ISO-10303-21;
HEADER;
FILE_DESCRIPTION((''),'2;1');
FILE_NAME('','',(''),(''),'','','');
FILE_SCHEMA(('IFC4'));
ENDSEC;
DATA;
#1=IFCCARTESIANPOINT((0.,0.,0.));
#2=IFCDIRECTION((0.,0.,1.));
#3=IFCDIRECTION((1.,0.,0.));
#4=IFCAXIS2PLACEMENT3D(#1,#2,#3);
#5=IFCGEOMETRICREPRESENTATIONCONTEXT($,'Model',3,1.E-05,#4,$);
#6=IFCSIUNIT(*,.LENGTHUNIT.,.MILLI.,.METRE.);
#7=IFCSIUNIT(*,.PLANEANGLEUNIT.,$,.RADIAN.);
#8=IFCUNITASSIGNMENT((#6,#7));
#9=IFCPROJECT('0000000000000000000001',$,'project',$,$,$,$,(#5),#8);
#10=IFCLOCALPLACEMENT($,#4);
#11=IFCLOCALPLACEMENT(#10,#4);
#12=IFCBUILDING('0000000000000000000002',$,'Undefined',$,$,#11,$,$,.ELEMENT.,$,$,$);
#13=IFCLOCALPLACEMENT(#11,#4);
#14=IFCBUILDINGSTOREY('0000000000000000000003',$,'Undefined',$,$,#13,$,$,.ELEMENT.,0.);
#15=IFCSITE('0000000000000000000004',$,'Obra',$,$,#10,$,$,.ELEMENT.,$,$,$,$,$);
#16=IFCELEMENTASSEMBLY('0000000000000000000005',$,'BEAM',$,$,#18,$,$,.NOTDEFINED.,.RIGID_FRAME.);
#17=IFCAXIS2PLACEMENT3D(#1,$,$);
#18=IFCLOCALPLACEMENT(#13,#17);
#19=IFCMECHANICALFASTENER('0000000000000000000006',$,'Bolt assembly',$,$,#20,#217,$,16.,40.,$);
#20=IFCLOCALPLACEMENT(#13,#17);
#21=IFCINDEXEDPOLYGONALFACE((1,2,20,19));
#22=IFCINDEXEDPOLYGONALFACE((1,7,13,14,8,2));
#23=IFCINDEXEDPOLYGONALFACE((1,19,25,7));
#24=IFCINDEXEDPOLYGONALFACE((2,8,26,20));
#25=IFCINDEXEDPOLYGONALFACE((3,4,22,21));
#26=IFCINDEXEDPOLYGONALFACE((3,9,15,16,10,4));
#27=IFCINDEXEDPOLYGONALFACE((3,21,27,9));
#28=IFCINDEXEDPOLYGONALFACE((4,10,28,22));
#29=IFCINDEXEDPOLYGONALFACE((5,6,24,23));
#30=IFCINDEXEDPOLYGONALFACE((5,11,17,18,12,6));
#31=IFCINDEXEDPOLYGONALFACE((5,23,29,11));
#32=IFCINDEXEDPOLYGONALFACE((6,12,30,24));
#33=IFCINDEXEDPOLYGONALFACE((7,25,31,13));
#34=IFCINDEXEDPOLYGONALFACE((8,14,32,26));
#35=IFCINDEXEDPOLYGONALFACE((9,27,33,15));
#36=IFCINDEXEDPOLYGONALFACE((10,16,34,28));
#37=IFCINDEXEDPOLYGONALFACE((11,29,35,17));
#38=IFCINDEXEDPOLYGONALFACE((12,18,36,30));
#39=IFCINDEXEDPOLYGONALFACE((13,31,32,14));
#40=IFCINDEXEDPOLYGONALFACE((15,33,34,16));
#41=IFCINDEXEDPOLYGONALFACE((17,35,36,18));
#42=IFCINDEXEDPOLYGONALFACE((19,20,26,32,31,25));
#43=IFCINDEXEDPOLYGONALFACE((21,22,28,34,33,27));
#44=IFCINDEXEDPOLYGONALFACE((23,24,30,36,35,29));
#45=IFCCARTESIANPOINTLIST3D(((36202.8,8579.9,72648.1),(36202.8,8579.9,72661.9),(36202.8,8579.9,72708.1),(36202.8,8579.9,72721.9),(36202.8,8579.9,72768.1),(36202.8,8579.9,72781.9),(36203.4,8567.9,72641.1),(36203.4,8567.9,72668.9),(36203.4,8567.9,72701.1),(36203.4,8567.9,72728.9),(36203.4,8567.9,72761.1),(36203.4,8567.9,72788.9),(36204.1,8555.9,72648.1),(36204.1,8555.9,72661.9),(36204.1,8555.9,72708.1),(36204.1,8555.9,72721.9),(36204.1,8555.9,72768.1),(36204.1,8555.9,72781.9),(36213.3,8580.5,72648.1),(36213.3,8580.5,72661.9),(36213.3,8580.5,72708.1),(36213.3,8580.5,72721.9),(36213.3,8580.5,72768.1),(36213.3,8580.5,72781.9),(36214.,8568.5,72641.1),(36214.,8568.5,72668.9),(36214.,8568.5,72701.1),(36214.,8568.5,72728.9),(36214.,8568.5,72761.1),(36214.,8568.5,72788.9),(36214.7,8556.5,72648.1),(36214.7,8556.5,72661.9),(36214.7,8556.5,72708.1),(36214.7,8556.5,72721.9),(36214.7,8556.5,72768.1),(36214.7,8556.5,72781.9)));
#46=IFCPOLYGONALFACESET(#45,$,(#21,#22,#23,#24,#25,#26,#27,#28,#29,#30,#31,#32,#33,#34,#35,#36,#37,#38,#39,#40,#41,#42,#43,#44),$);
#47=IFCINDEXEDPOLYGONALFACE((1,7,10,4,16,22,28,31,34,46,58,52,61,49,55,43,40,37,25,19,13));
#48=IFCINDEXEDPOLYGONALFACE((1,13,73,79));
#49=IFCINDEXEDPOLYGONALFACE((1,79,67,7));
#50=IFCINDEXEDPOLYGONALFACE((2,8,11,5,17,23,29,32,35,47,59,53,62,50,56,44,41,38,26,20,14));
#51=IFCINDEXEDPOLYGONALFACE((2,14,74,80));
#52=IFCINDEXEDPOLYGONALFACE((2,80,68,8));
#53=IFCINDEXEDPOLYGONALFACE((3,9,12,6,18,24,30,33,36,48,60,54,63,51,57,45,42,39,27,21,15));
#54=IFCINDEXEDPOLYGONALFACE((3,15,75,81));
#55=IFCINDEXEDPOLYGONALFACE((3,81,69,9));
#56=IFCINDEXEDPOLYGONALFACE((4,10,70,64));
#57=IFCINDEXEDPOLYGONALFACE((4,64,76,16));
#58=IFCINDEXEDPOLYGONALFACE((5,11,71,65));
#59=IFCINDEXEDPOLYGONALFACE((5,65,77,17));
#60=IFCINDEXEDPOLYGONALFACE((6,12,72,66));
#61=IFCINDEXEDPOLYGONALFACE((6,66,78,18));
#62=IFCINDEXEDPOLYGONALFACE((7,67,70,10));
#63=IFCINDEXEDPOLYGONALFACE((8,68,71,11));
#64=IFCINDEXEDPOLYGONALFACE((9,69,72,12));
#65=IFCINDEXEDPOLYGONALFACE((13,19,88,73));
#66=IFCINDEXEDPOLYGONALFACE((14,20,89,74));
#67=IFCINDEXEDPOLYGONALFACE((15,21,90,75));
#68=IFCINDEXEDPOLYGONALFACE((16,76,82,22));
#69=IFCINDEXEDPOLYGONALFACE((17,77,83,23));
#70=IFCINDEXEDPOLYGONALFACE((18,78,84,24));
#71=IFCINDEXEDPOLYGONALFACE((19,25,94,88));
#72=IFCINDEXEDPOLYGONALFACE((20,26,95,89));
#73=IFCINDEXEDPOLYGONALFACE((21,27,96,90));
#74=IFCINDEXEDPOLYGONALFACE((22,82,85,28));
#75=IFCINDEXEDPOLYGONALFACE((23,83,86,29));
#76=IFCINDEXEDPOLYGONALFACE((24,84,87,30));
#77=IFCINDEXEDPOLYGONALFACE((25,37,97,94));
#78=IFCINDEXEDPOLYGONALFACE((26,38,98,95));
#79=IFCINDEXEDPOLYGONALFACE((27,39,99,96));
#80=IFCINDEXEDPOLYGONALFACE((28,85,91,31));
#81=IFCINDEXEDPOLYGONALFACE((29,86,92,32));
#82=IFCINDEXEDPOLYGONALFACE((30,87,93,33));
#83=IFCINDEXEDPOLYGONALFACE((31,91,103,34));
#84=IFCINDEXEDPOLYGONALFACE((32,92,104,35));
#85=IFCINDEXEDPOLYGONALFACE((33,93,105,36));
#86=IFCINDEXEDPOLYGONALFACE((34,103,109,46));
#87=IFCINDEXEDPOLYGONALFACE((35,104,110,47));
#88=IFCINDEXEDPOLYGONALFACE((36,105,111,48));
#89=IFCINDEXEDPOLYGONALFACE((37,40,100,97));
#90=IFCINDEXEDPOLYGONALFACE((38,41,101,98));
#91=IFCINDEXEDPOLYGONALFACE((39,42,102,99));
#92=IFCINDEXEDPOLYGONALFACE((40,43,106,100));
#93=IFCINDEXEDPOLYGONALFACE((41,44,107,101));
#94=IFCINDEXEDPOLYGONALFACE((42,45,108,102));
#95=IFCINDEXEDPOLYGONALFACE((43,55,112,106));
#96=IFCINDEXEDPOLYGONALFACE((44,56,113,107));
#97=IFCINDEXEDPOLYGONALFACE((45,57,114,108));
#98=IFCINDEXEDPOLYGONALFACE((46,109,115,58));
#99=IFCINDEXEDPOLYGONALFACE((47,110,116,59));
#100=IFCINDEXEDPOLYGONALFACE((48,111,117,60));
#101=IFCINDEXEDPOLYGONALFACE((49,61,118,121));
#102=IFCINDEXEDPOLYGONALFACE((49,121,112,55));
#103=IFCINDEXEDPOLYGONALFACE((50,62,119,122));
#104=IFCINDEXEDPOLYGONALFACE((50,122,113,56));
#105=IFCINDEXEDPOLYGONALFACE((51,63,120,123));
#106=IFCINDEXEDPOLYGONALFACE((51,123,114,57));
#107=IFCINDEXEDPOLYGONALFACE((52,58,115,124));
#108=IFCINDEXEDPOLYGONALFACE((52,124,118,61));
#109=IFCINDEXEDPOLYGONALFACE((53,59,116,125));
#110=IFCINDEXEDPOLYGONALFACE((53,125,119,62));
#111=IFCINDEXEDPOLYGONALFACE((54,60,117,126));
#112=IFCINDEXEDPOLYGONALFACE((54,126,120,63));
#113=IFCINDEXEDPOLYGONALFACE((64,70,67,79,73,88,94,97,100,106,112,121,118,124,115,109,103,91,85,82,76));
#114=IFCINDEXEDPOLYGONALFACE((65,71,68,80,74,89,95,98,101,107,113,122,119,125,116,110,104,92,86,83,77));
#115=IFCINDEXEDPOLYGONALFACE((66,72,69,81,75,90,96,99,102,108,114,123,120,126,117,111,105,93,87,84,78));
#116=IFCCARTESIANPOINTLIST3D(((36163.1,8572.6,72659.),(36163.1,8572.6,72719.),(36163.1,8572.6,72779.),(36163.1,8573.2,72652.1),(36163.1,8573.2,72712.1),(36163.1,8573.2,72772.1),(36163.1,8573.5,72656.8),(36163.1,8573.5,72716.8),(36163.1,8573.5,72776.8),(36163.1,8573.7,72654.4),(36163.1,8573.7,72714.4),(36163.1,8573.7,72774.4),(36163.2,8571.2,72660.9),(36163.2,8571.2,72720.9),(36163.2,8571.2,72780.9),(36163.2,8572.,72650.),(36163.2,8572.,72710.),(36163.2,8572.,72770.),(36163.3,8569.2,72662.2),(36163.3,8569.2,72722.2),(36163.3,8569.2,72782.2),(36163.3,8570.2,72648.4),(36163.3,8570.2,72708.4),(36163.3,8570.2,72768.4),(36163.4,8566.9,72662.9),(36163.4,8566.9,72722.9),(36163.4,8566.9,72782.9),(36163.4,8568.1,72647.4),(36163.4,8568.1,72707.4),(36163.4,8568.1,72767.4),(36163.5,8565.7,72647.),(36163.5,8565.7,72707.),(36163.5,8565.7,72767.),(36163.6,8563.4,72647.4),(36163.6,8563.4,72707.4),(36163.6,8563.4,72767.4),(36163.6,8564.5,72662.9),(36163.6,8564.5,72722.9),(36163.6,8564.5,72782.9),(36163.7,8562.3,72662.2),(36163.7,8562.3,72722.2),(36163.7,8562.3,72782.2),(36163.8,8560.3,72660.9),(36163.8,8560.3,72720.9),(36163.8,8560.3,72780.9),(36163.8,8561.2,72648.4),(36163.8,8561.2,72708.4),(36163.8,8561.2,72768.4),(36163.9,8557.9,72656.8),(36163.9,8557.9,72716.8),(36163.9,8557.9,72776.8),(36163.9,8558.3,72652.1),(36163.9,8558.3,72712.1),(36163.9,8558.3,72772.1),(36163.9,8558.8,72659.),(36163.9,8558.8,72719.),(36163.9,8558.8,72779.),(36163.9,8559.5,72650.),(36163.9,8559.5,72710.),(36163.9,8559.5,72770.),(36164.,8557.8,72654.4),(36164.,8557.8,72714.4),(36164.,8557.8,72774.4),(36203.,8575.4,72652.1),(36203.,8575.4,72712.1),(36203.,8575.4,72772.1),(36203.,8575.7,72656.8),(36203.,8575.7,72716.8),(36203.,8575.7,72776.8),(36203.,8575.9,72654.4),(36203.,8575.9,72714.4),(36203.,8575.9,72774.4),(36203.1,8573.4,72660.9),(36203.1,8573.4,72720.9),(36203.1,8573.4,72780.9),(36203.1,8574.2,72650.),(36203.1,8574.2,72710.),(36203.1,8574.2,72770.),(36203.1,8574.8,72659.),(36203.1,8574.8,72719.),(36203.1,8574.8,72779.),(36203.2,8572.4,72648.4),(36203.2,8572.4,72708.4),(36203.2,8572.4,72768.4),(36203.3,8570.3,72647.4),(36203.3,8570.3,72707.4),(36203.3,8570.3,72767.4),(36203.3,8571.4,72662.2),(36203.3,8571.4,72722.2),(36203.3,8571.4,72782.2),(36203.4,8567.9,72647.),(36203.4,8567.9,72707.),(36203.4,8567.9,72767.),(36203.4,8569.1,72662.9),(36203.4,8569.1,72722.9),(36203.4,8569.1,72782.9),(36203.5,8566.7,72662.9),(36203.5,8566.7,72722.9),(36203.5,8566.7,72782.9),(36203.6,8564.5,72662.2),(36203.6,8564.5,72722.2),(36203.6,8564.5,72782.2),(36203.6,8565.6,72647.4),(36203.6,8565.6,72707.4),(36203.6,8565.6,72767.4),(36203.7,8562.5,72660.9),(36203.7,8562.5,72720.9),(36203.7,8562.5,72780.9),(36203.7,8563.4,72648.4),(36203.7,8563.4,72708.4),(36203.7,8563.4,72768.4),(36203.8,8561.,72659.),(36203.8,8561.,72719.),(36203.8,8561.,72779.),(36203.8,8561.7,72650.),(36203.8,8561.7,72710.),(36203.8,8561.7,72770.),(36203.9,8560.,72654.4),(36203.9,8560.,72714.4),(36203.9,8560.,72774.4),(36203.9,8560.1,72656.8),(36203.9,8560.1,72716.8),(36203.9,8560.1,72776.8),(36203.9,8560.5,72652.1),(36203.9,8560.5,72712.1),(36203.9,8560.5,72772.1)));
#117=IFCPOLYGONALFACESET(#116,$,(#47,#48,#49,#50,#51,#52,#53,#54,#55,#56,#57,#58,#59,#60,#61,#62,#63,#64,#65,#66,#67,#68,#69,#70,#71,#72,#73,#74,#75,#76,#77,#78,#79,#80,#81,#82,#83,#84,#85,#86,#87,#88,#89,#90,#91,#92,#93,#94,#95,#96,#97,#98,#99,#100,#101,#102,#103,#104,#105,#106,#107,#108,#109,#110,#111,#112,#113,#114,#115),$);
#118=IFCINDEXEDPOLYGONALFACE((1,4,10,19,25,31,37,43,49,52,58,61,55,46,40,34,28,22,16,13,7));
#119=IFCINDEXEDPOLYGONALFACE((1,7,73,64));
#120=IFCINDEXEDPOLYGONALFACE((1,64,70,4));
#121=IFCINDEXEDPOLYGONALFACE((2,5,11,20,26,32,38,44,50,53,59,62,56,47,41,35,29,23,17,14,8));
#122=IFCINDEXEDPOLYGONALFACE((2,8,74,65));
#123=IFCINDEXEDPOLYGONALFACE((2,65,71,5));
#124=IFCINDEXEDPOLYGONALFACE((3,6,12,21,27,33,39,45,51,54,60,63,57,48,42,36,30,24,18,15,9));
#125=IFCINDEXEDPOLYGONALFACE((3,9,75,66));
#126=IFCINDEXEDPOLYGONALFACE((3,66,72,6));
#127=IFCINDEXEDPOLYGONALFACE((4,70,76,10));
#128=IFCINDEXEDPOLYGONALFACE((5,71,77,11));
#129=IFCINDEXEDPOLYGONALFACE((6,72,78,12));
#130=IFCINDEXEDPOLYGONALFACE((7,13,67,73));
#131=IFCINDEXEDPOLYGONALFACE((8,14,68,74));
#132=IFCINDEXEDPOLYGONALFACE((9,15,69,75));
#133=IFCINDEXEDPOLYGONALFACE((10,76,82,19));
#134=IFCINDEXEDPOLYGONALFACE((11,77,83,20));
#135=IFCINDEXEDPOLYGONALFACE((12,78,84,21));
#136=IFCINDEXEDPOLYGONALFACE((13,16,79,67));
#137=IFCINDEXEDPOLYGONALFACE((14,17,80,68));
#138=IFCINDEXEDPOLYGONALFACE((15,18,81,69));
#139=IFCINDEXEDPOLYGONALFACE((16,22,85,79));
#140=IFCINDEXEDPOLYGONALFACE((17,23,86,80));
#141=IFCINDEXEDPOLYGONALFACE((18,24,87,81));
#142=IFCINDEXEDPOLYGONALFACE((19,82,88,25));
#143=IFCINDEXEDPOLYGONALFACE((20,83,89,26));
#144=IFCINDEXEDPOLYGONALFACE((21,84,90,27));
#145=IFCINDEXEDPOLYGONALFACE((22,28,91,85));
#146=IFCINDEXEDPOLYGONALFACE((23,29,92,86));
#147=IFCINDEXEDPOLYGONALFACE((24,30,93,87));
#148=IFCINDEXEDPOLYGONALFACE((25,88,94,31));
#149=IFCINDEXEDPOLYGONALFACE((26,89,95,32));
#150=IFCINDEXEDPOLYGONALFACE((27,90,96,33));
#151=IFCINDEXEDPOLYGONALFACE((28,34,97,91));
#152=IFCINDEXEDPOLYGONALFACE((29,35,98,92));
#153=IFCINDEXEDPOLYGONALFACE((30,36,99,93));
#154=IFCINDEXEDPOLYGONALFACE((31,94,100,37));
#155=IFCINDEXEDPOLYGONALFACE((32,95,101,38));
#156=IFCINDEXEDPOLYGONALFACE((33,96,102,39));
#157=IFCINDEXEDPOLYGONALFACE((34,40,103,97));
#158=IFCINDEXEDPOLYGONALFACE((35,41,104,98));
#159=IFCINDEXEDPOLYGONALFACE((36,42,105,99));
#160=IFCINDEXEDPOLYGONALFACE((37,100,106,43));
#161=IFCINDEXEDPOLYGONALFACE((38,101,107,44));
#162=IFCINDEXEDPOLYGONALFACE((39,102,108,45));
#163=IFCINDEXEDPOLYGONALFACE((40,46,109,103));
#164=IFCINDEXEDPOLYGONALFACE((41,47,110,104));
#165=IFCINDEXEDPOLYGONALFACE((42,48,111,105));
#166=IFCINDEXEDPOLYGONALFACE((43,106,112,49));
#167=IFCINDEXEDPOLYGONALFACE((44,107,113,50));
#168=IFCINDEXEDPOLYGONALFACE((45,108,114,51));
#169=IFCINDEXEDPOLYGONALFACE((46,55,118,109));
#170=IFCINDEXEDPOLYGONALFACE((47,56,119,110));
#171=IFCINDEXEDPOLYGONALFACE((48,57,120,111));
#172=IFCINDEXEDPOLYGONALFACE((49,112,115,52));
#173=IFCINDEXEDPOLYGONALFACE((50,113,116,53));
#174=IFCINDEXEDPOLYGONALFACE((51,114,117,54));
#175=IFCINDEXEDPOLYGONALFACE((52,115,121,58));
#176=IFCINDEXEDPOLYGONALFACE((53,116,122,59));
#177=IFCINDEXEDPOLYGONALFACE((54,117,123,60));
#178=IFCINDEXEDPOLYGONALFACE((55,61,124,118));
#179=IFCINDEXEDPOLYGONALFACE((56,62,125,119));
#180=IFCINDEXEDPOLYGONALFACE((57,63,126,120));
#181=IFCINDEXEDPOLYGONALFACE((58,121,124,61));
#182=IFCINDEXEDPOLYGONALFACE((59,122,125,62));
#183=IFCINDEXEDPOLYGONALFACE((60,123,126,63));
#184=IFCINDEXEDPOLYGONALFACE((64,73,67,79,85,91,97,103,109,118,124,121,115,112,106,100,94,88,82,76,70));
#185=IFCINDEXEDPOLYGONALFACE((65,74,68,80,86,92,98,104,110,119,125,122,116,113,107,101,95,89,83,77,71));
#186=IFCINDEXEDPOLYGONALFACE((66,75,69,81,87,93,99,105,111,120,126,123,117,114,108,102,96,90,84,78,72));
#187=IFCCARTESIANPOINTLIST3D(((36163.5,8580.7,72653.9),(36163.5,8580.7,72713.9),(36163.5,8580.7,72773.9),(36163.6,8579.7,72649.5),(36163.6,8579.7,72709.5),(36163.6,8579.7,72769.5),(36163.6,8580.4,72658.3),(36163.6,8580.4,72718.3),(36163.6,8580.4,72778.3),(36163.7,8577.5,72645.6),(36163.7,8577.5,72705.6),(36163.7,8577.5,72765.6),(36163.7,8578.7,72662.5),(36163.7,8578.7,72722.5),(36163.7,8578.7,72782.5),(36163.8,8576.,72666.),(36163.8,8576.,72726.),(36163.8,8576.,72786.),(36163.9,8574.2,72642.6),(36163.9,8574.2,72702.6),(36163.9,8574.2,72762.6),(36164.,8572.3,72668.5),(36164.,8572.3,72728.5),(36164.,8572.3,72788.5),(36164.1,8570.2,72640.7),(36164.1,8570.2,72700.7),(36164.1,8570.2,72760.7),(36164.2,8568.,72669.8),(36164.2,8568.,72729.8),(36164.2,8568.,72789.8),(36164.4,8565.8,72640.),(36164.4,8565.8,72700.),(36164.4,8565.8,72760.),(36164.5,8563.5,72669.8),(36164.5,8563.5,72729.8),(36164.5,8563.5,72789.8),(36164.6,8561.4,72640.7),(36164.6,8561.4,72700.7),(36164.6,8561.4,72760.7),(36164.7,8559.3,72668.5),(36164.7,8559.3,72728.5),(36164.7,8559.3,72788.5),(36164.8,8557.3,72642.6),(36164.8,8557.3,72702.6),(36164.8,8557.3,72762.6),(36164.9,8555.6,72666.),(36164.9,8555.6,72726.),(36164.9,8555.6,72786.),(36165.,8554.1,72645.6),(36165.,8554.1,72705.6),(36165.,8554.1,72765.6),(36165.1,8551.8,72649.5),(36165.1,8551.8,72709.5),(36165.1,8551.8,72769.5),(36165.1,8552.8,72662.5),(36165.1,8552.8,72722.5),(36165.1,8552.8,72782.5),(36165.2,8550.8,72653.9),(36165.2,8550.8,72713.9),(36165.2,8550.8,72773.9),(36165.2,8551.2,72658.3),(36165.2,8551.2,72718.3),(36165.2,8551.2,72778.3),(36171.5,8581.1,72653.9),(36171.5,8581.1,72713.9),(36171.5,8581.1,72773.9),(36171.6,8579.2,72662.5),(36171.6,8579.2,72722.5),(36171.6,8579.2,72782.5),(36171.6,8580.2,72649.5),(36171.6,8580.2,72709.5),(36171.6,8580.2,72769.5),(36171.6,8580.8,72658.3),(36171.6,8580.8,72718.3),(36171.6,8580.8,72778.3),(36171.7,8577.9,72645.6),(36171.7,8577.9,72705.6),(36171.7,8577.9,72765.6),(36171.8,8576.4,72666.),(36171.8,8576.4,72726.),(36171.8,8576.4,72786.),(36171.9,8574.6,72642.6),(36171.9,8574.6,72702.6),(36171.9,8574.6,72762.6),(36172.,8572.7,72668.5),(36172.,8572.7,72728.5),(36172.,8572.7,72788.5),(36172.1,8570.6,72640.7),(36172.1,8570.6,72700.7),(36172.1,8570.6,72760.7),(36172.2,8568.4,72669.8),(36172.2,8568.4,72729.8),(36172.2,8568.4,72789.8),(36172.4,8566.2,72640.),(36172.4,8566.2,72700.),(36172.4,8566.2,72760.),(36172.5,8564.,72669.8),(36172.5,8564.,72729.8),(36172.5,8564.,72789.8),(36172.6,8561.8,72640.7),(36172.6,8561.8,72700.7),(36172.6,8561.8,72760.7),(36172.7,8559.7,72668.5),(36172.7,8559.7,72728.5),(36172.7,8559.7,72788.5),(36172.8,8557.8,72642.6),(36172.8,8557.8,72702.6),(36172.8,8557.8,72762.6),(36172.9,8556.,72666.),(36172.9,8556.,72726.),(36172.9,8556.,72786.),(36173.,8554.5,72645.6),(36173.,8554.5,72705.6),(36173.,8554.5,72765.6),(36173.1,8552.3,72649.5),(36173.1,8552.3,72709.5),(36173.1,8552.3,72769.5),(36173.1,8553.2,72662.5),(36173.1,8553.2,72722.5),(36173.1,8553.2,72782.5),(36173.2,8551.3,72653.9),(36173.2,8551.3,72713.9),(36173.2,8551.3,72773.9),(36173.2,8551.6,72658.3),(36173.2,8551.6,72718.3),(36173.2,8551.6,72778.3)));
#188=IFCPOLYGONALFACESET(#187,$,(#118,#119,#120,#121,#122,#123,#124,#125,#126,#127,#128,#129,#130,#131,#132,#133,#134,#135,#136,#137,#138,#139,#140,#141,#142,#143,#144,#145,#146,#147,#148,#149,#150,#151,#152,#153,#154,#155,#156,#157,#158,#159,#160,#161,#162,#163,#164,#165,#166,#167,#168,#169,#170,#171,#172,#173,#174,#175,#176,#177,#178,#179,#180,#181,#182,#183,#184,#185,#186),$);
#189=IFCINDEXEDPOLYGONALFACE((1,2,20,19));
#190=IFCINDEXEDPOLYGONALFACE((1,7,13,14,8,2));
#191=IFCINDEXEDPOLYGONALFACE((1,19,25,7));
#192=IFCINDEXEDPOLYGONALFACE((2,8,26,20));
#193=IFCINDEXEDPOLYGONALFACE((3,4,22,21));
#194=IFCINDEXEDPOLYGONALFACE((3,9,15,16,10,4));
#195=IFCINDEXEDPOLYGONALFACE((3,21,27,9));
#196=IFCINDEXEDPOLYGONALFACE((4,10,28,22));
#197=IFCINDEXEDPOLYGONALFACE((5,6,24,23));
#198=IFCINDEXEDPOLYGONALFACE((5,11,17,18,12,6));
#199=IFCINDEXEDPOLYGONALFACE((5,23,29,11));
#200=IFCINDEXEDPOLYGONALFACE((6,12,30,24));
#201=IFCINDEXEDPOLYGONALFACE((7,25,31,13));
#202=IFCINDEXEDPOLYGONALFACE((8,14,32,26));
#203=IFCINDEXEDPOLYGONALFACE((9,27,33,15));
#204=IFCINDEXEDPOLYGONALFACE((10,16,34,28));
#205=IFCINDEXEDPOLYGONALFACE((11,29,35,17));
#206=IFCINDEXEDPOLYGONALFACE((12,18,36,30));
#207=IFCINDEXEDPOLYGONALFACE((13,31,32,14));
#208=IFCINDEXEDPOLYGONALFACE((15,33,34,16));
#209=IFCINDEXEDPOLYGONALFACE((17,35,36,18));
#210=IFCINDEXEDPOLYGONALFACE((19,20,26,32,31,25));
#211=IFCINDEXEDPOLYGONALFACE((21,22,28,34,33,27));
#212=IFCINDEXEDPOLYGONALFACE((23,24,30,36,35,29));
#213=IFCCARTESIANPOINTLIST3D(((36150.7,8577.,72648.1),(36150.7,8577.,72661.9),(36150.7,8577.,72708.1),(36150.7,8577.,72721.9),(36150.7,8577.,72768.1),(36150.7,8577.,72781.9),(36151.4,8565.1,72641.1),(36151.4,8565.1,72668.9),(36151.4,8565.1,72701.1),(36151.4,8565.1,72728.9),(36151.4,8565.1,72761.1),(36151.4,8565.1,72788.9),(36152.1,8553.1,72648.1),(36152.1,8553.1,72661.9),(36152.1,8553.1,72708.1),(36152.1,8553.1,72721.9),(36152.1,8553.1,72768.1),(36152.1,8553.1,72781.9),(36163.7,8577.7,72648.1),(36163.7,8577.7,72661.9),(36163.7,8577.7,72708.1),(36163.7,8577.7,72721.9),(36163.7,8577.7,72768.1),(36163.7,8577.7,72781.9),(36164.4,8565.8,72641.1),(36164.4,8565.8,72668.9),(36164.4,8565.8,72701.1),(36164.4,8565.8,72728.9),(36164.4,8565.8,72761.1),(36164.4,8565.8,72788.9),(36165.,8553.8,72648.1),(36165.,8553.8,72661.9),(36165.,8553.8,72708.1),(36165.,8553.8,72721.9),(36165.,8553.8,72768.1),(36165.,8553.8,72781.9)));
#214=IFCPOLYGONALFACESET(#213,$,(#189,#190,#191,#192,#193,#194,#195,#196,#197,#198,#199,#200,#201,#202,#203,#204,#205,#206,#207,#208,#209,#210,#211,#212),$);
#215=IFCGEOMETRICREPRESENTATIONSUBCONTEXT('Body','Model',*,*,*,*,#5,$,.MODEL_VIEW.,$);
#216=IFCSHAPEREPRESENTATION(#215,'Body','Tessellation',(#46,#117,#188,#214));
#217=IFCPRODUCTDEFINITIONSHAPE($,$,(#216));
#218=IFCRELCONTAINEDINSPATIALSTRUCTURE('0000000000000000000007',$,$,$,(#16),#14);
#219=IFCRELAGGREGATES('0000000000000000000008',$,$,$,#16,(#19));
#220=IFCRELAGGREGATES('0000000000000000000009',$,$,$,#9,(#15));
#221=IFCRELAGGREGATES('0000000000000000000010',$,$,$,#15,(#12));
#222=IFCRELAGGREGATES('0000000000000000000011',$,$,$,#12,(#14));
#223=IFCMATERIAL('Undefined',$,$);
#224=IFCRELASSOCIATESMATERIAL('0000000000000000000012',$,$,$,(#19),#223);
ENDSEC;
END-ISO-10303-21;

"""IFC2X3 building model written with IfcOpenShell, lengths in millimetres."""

from ifc_helpers import new_model, si_unit, frame, origin_with_axes, origin_2d_with_axis, place, context, subcontext, project, spatial, polyline, circle, outline, extrude, source, transform, mapped, material, element, aggregate, save


model = new_model("IFC2X3")

# Units and contexts
model_context = context("Model", 3, precision=1e-05, world=origin_with_axes())
body_context = subcontext(model_context, "Body", "Model", "MODEL_VIEW")
ifc_project = project(units=[si_unit("LENGTHUNIT", "METRE", prefix="MILLI"), si_unit("PLANEANGLEUNIT", "RADIAN")], contexts=[model_context])

# Site, building, storey
site_placement = place(None, origin_with_axes())
site = spatial("IfcSite", under=ifc_project, at=site_placement, Name="Obra", CompositionType="ELEMENT")
building_placement = place(site_placement, origin_with_axes())
building = spatial("IfcBuilding", under=site, at=building_placement, Name="Undefined", CompositionType="ELEMENT")
storey_placement = place(building_placement, origin_with_axes())
storey = spatial("IfcBuildingStorey", under=building, at=storey_placement, Name="Undefined", CompositionType="ELEMENT", Elevation=0.0)

# Element assembly
assembly_1_placement = place(storey_placement, origin_with_axes())
assembly_1 = element("IfcElementAssembly", 1, at=assembly_1_placement, inside=storey, Name="BEAM", AssemblyPlace="NOTDEFINED", PredefinedType="RIGID_FRAME")

# Shared definitions
ifc_material_1 = material(Name="Undefined")
shared_shape_1 = source(origin_with_axes(), body_context, "Body", "SweptSolid", [
    extrude(outline(polyline([(13.9, 0.0), (6.9, 12.0), (-6.9, 12.0), (-13.9, 0.0), (-6.9, -12.0), (6.9, -12.0), (13.9, 0.0)])), frame((0.0, -44.8, 0.0), z_axis=(0.0, 1.0, 0.0), x_axis=(1.0, 0.0, 0.0)), (0.0, 0.0, 1.0), 10.6),
    extrude(circle(Radius=8.0, at=origin_2d_with_axis()), frame((0.0, -34.2, 0.0), z_axis=(0.0, 1.0, 0.0), x_axis=(1.0, 0.0, 0.0)), (0.0, 0.0, 1.0), 40.0),
    extrude(circle(Radius=15.0, at=origin_2d_with_axis()), frame((0.0, -3.1, 0.0), z_axis=(0.0, 1.0, 0.0), x_axis=(1.0, 0.0, 0.0)), (0.0, 0.0, 1.0), 8.0),
    extrude(outline(polyline([(13.9, 0.0), (6.9, 12.0), (-6.9, 12.0), (-13.9, 0.0), (-6.9, -12.0), (6.9, -12.0), (13.9, 0.0)])), frame((0.0, 4.9, 0.0), z_axis=(0.0, 1.0, 0.0), x_axis=(1.0, 0.0, 0.0)), (0.0, 0.0, 1.0), 13.0),
])

# Mechanical fastener
mechanical_fastener_1_placement = place(assembly_1_placement, frame((36172.0, 8516.1, 72835.0), z_axis=(-0.055152, 0.998478, 0.0), x_axis=(0.0, 0.0, -1.0)))
mechanical_fastener_1 = element("IfcMechanicalFastener", 2, at=mechanical_fastener_1_placement, material=ifc_material_1, Name="Bolt assembly", NominalDiameter=16.0, NominalLength=40.0, context=body_context, shape_type="MappedRepresentation", body=[
    mapped(shared_shape_1, transform((60.0, 0.0, 50.0))),
    mapped(shared_shape_1, transform((120.0, 0.0, 50.0))),
    mapped(shared_shape_1, transform((180.0, 0.0, 50.0))),
])
aggregate(assembly_1, [mechanical_fastener_1])

save(model, "model.ifc")
